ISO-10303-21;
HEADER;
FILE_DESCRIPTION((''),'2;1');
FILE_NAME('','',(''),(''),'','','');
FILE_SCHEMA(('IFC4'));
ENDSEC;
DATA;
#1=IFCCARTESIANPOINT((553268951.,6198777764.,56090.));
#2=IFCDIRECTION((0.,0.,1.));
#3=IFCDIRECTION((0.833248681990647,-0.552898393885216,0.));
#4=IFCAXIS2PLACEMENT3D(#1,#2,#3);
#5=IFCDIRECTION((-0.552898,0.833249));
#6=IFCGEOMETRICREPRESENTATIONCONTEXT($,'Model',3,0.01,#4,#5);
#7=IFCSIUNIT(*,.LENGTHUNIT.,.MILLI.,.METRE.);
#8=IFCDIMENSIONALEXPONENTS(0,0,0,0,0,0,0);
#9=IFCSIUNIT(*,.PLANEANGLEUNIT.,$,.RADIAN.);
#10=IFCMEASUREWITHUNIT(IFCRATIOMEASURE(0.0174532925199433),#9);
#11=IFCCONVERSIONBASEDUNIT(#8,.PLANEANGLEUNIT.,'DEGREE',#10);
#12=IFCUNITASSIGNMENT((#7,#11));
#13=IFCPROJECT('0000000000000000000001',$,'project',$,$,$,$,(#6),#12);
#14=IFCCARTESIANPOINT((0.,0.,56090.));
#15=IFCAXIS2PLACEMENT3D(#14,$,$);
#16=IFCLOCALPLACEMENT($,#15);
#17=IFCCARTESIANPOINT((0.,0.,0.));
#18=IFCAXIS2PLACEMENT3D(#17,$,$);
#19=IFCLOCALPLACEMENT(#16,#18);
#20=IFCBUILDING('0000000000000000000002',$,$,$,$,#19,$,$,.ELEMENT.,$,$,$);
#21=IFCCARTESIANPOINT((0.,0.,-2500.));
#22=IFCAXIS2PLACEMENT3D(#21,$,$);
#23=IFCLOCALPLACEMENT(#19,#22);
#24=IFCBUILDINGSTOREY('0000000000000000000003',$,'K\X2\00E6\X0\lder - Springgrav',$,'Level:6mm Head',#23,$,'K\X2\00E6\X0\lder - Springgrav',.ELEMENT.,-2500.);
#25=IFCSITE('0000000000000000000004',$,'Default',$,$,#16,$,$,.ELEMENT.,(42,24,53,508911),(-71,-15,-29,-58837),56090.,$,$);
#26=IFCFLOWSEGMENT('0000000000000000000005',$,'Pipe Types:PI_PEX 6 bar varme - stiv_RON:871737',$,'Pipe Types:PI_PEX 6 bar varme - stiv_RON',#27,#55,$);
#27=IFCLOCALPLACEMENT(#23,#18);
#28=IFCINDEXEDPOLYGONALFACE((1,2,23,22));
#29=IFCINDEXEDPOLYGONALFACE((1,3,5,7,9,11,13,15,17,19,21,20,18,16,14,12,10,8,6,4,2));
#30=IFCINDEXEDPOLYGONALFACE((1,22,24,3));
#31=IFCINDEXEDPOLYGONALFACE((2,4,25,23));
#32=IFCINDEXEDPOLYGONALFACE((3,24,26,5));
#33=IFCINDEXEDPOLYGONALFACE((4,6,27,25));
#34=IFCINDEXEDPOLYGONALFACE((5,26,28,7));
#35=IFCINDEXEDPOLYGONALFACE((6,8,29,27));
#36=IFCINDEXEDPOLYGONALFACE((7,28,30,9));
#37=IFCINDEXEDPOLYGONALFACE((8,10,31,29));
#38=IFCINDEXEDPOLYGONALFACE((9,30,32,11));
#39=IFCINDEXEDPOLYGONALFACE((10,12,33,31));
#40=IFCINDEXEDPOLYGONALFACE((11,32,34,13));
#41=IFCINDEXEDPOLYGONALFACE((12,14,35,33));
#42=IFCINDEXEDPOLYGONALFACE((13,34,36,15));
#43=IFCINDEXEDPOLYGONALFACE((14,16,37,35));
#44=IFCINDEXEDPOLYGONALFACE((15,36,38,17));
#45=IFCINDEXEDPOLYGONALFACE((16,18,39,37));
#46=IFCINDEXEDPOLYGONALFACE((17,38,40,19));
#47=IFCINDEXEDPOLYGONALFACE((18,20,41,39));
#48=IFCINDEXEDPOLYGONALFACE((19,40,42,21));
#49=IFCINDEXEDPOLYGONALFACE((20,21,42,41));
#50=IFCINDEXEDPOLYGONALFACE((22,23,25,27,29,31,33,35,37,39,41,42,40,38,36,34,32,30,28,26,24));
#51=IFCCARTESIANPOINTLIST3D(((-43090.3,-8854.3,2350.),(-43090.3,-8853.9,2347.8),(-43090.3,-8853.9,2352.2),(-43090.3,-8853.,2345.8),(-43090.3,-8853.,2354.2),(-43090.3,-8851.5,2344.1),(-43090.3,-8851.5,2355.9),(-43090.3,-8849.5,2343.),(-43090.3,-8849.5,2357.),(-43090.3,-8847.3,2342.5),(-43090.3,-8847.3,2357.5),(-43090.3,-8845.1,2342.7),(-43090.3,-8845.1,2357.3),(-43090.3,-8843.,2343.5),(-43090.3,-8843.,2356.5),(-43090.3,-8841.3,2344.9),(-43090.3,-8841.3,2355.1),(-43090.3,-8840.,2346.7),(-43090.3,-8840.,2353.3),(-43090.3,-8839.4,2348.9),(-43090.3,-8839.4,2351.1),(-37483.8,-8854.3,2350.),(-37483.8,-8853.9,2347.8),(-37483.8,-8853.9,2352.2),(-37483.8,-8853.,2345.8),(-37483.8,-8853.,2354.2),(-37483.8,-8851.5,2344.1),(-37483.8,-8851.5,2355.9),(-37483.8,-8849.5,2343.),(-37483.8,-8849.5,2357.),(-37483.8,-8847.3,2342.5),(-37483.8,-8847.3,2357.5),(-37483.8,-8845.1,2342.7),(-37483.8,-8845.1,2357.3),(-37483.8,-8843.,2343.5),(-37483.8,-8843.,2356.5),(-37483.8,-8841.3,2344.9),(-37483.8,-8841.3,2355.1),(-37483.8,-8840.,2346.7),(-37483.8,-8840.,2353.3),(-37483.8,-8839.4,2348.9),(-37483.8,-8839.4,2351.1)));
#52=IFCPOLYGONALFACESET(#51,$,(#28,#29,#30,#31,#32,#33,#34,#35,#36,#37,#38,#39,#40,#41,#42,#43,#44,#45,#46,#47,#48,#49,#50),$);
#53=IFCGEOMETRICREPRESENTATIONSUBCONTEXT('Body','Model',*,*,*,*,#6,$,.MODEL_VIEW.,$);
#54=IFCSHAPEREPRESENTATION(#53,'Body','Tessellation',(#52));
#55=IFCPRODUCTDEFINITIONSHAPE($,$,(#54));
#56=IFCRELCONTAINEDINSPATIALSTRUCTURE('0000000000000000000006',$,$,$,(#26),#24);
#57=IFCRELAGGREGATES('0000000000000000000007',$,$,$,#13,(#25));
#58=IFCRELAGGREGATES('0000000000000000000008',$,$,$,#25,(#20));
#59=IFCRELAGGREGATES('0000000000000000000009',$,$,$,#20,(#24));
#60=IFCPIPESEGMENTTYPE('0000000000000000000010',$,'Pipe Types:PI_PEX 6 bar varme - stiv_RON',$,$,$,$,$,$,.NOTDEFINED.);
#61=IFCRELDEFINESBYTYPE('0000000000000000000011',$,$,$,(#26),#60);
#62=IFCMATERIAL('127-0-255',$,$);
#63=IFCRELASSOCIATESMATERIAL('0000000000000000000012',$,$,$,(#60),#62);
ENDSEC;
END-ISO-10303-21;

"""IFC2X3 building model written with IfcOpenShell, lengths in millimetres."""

from ifc_helpers import new_model, entity, si_unit, converted_unit, direction, frame, frame_2d, origin, place, context, subcontext, project, spatial, circle, extrude, material, type_object, element, save


model = new_model("IFC2X3")

# Units and contexts
model_context = context("Model", 3, precision=0.01, world=frame((553268951.0, 6198777764.0, 56090.0), z_axis=(0.0, 0.0, 1.0), x_axis=(0.833248681990647, -0.552898393885216, 0.0)), true_north=direction((-0.552898, 0.833249)))
body_context = subcontext(model_context, "Body", "Model", "MODEL_VIEW")
ifc_project = project(units=[si_unit("LENGTHUNIT", "METRE", prefix="MILLI"), converted_unit("PLANEANGLEUNIT", "DEGREE", entity("IfcRatioMeasure", 0.0174532925199433), si_unit("PLANEANGLEUNIT", "RADIAN"), dimensions=[0, 0, 0, 0, 0, 0, 0])], contexts=[model_context])

# Site, building, storey
site_placement = place(None, frame((0.0, 0.0, 56090.0)))
site = spatial("IfcSite", under=ifc_project, at=site_placement, Name="Default", CompositionType="ELEMENT", RefLatitude=(42, 24, 53, 508911), RefLongitude=(-71, -15, -29, -58837), RefElevation=56090.0)
building_placement = place(site_placement, origin())
building = spatial("IfcBuilding", under=site, at=building_placement, CompositionType="ELEMENT")
storey_placement = place(building_placement, frame((0.0, 0.0, -2500.0)))
storey = spatial("IfcBuildingStorey", under=building, at=storey_placement, Name="Kælder - Springgrav", ObjectType="Level:6mm Head", LongName="Kælder - Springgrav", CompositionType="ELEMENT", Elevation=-2500.0)

# Flow segment
ifc_material = material(Name="127-0-255")
pipe_segment_type = type_object("IfcPipeSegmentType", Name="Pipe Types:PI_PEX 6 bar varme - stiv_RON", PredefinedType="NOTDEFINED", material=ifc_material)
flow_segment_placement = place(storey_placement, origin())
element("IfcFlowSegment", 1, at=flow_segment_placement, inside=storey, type_object=pipe_segment_type, Name="Pipe Types:PI_PEX 6 bar varme - stiv_RON:871737", ObjectType="Pipe Types:PI_PEX 6 bar varme - stiv_RON", context=body_context, shape_type="SweptSolid", body=[
    extrude(circle(Radius=7.5, at=frame_2d((0.0, 0.0), x_axis=(1.0, 0.0))), frame((-43090.3, -8846.8, 2350.0), z_axis=(1.0, 0.0, 0.0), x_axis=(0.0, -1.0, 0.0)), (0.0, 0.0, 1.0), 5606.5),
])

save(model, "model.ifc")
